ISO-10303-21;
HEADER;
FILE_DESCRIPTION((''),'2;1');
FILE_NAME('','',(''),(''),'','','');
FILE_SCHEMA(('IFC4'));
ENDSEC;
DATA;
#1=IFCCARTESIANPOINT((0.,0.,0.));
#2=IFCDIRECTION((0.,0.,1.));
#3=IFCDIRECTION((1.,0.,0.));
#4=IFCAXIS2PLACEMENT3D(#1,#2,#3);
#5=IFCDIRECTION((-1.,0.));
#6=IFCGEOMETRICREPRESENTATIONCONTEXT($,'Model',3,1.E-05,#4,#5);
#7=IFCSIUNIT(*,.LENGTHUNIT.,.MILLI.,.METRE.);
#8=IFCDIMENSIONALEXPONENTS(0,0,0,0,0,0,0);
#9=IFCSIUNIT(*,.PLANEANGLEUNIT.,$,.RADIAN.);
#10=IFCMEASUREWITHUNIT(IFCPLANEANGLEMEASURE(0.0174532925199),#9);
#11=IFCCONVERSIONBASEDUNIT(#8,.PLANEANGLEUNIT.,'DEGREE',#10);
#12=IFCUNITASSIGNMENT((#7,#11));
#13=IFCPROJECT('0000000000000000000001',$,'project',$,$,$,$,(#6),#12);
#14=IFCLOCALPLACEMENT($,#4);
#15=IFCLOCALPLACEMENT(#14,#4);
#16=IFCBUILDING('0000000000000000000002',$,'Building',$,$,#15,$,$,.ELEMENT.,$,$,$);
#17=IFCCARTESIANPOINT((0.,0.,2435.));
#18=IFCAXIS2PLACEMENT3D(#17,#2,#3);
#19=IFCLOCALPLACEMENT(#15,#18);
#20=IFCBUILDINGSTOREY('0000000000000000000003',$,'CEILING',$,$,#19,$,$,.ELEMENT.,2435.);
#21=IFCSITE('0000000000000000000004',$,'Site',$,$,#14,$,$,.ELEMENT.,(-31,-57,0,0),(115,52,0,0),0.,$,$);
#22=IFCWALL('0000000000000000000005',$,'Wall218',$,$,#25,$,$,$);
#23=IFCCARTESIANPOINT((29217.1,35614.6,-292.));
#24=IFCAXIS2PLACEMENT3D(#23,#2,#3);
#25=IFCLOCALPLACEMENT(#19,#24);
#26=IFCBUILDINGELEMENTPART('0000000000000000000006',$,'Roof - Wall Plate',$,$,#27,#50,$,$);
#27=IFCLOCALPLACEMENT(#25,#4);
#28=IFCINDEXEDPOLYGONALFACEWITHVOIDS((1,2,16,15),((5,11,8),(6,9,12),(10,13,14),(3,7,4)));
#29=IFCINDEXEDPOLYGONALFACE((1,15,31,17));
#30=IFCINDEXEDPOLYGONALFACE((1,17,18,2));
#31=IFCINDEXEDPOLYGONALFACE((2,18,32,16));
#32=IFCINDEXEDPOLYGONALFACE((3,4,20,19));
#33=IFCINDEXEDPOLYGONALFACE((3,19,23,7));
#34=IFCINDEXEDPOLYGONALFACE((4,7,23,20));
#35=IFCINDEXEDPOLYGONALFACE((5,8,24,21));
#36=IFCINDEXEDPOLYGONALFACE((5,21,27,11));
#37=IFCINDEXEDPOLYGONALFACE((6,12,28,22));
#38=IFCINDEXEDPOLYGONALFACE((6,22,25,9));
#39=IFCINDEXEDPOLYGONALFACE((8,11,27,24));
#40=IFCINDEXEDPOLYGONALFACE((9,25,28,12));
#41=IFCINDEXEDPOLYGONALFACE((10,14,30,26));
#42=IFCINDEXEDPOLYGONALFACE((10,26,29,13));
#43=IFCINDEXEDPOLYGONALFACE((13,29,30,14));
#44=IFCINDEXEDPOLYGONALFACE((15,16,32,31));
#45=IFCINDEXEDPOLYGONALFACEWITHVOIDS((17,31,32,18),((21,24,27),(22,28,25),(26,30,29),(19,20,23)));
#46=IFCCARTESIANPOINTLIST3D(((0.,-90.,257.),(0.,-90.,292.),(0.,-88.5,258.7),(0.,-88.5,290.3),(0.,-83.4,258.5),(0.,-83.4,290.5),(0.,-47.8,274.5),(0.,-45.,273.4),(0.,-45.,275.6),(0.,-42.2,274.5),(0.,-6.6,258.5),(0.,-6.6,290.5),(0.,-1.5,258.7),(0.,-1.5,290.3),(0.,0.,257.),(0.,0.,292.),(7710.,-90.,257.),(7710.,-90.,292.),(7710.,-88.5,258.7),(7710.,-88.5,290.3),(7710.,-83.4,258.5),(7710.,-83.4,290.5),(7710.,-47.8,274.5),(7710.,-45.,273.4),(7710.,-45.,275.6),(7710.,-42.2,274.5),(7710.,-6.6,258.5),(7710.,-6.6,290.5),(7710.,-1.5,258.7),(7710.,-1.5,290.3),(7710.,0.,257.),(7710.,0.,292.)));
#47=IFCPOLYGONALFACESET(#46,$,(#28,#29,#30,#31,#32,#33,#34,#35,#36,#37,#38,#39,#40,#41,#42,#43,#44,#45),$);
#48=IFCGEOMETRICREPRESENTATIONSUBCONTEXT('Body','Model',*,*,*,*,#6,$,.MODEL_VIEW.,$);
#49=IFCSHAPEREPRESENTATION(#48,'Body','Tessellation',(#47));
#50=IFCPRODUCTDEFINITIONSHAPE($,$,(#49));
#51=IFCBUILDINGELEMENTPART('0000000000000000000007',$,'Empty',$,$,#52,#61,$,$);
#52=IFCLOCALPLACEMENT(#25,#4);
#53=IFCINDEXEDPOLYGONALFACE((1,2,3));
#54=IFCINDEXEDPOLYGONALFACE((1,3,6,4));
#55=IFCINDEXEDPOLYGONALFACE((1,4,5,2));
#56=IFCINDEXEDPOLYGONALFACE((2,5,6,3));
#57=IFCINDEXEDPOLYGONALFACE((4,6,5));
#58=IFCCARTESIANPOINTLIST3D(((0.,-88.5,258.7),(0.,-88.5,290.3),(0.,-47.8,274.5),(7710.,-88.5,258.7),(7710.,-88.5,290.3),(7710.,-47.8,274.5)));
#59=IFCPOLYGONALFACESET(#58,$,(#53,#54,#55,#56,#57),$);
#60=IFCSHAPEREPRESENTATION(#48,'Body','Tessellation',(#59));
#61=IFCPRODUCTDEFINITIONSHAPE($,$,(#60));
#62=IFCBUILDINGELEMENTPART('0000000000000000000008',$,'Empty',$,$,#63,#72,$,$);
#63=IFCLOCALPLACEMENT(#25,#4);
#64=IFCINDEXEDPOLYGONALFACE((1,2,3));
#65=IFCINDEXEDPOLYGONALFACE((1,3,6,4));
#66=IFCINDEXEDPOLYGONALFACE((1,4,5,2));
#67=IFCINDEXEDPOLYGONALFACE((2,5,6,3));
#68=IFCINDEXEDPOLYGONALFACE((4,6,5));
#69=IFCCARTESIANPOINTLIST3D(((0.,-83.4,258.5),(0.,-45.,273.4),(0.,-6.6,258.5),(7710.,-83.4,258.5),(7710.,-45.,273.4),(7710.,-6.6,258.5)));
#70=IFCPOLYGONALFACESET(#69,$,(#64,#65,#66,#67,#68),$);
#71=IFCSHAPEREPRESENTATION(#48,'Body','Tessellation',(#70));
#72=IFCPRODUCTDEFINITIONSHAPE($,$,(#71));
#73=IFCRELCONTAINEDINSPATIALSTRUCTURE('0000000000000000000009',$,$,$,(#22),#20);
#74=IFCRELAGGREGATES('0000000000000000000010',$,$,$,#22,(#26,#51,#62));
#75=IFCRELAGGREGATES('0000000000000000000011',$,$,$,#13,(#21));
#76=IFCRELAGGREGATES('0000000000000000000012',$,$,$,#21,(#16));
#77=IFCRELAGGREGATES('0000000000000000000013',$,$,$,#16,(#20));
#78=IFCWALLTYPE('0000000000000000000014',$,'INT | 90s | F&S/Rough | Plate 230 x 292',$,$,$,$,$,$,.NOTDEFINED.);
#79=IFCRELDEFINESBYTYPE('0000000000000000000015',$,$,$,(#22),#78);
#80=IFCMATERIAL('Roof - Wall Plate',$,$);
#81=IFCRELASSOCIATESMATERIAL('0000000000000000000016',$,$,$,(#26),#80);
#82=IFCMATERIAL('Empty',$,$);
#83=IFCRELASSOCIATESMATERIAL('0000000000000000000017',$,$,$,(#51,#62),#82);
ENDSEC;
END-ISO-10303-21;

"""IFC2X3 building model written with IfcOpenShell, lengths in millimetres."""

from ifc_helpers import new_model, entity, si_unit, converted_unit, direction, frame, origin_with_axes, place, context, subcontext, project, spatial, polyline, outline, extrude, material, type_object, element, aggregate, save


model = new_model("IFC2X3")

# Units and contexts
model_context = context("Model", 3, precision=1e-05, world=origin_with_axes(), true_north=direction((-1.0, 0.0)))
body_context = subcontext(model_context, "Body", "Model", "MODEL_VIEW")
ifc_project = project(units=[si_unit("LENGTHUNIT", "METRE", prefix="MILLI"), converted_unit("PLANEANGLEUNIT", "DEGREE", entity("IfcPlaneAngleMeasure", 0.0174532925199), si_unit("PLANEANGLEUNIT", "RADIAN"), dimensions=[0, 0, 0, 0, 0, 0, 0])], contexts=[model_context])

# Site, building, storey
site_placement = place(None, origin_with_axes())
site = spatial("IfcSite", under=ifc_project, at=site_placement, Name="Site", CompositionType="ELEMENT", RefLatitude=(-31, -57, 0, 0), RefLongitude=(115, 52, 0, 0), RefElevation=0.0)
building_placement = place(site_placement, origin_with_axes())
building = spatial("IfcBuilding", under=site, at=building_placement, Name="Building", CompositionType="ELEMENT")
storey_placement = place(building_placement, frame((0.0, 0.0, 2435.0), z_axis=(0.0, 0.0, 1.0), x_axis=(1.0, 0.0, 0.0)))
storey = spatial("IfcBuildingStorey", under=building, at=storey_placement, Name="CEILING", CompositionType="ELEMENT", Elevation=2435.0)

# Wall, building element parts
wall_type = type_object("IfcWallType", Name="INT | 90s | F&S/Rough | Plate 230 x 292", PredefinedType="NOTDEFINED")
ifc_material_1 = material(Name="Roof - Wall Plate")
ifc_material_2 = material(Name="Empty")
wall_1_placement = place(storey_placement, frame((29217.1, 35614.6, -292.0), z_axis=(0.0, 0.0, 1.0), x_axis=(1.0, 0.0, 0.0)))
wall_1 = element("IfcWall", 1, at=wall_1_placement, inside=storey, type_object=wall_type, Name="Wall218")
building_element_part_1_placement = place(wall_1_placement, origin_with_axes())
building_element_part_1 = element("IfcBuildingElementPart", 2, at=building_element_part_1_placement, material=ifc_material_1, Name="Roof - Wall Plate", context=body_context, shape_type="SweptSolid", body=[
    extrude(outline(polyline([(-90.0, 257.0), (0.0, 257.0), (0.0, 292.0), (-90.0, 292.0), (-90.0, 257.0)]), holes=[polyline([(-83.4, 290.5), (-6.6, 290.5), (-45.0, 275.6), (-83.4, 290.5)]), polyline([(-42.2, 274.5), (-1.5, 290.3), (-1.5, 258.7), (-42.2, 274.5)]), polyline([(-6.6, 258.5), (-83.4, 258.5), (-45.0, 273.4), (-6.6, 258.5)]), polyline([(-88.5, 258.7), (-88.5, 290.3), (-47.8, 274.5), (-88.5, 258.7)])]), frame((0.0, 0.0, 0.0), z_axis=(1.0, 0.0, 0.0), x_axis=(0.0, 1.0, 0.0)), (0.0, 0.0, 1.0), 7710.0),
])
building_element_part_2_placement = place(wall_1_placement, origin_with_axes())
building_element_part_2 = element("IfcBuildingElementPart", 3, at=building_element_part_2_placement, material=ifc_material_2, Name="Empty", context=body_context, shape_type="SweptSolid", body=[
    extrude(outline(polyline([(-47.8, 274.5), (-88.5, 290.3), (-88.5, 258.7), (-47.8, 274.5)])), frame((0.0, 0.0, 0.0), z_axis=(1.0, 0.0, 0.0), x_axis=(0.0, 1.0, 0.0)), (0.0, 0.0, 1.0), 7710.0),
])
building_element_part_3_placement = place(wall_1_placement, origin_with_axes())
building_element_part_3 = element("IfcBuildingElementPart", 4, at=building_element_part_3_placement, material=ifc_material_2, Name="Empty", context=body_context, shape_type="SweptSolid", body=[
    extrude(outline(polyline([(-6.6, 258.5), (-45.0, 273.4), (-83.4, 258.5), (-6.6, 258.5)])), frame((0.0, 0.0, 0.0), z_axis=(1.0, 0.0, 0.0), x_axis=(0.0, 1.0, 0.0)), (0.0, 0.0, 1.0), 7710.0),
])
aggregate(wall_1, [building_element_part_1, building_element_part_2, building_element_part_3])

save(model, "model.ifc")
